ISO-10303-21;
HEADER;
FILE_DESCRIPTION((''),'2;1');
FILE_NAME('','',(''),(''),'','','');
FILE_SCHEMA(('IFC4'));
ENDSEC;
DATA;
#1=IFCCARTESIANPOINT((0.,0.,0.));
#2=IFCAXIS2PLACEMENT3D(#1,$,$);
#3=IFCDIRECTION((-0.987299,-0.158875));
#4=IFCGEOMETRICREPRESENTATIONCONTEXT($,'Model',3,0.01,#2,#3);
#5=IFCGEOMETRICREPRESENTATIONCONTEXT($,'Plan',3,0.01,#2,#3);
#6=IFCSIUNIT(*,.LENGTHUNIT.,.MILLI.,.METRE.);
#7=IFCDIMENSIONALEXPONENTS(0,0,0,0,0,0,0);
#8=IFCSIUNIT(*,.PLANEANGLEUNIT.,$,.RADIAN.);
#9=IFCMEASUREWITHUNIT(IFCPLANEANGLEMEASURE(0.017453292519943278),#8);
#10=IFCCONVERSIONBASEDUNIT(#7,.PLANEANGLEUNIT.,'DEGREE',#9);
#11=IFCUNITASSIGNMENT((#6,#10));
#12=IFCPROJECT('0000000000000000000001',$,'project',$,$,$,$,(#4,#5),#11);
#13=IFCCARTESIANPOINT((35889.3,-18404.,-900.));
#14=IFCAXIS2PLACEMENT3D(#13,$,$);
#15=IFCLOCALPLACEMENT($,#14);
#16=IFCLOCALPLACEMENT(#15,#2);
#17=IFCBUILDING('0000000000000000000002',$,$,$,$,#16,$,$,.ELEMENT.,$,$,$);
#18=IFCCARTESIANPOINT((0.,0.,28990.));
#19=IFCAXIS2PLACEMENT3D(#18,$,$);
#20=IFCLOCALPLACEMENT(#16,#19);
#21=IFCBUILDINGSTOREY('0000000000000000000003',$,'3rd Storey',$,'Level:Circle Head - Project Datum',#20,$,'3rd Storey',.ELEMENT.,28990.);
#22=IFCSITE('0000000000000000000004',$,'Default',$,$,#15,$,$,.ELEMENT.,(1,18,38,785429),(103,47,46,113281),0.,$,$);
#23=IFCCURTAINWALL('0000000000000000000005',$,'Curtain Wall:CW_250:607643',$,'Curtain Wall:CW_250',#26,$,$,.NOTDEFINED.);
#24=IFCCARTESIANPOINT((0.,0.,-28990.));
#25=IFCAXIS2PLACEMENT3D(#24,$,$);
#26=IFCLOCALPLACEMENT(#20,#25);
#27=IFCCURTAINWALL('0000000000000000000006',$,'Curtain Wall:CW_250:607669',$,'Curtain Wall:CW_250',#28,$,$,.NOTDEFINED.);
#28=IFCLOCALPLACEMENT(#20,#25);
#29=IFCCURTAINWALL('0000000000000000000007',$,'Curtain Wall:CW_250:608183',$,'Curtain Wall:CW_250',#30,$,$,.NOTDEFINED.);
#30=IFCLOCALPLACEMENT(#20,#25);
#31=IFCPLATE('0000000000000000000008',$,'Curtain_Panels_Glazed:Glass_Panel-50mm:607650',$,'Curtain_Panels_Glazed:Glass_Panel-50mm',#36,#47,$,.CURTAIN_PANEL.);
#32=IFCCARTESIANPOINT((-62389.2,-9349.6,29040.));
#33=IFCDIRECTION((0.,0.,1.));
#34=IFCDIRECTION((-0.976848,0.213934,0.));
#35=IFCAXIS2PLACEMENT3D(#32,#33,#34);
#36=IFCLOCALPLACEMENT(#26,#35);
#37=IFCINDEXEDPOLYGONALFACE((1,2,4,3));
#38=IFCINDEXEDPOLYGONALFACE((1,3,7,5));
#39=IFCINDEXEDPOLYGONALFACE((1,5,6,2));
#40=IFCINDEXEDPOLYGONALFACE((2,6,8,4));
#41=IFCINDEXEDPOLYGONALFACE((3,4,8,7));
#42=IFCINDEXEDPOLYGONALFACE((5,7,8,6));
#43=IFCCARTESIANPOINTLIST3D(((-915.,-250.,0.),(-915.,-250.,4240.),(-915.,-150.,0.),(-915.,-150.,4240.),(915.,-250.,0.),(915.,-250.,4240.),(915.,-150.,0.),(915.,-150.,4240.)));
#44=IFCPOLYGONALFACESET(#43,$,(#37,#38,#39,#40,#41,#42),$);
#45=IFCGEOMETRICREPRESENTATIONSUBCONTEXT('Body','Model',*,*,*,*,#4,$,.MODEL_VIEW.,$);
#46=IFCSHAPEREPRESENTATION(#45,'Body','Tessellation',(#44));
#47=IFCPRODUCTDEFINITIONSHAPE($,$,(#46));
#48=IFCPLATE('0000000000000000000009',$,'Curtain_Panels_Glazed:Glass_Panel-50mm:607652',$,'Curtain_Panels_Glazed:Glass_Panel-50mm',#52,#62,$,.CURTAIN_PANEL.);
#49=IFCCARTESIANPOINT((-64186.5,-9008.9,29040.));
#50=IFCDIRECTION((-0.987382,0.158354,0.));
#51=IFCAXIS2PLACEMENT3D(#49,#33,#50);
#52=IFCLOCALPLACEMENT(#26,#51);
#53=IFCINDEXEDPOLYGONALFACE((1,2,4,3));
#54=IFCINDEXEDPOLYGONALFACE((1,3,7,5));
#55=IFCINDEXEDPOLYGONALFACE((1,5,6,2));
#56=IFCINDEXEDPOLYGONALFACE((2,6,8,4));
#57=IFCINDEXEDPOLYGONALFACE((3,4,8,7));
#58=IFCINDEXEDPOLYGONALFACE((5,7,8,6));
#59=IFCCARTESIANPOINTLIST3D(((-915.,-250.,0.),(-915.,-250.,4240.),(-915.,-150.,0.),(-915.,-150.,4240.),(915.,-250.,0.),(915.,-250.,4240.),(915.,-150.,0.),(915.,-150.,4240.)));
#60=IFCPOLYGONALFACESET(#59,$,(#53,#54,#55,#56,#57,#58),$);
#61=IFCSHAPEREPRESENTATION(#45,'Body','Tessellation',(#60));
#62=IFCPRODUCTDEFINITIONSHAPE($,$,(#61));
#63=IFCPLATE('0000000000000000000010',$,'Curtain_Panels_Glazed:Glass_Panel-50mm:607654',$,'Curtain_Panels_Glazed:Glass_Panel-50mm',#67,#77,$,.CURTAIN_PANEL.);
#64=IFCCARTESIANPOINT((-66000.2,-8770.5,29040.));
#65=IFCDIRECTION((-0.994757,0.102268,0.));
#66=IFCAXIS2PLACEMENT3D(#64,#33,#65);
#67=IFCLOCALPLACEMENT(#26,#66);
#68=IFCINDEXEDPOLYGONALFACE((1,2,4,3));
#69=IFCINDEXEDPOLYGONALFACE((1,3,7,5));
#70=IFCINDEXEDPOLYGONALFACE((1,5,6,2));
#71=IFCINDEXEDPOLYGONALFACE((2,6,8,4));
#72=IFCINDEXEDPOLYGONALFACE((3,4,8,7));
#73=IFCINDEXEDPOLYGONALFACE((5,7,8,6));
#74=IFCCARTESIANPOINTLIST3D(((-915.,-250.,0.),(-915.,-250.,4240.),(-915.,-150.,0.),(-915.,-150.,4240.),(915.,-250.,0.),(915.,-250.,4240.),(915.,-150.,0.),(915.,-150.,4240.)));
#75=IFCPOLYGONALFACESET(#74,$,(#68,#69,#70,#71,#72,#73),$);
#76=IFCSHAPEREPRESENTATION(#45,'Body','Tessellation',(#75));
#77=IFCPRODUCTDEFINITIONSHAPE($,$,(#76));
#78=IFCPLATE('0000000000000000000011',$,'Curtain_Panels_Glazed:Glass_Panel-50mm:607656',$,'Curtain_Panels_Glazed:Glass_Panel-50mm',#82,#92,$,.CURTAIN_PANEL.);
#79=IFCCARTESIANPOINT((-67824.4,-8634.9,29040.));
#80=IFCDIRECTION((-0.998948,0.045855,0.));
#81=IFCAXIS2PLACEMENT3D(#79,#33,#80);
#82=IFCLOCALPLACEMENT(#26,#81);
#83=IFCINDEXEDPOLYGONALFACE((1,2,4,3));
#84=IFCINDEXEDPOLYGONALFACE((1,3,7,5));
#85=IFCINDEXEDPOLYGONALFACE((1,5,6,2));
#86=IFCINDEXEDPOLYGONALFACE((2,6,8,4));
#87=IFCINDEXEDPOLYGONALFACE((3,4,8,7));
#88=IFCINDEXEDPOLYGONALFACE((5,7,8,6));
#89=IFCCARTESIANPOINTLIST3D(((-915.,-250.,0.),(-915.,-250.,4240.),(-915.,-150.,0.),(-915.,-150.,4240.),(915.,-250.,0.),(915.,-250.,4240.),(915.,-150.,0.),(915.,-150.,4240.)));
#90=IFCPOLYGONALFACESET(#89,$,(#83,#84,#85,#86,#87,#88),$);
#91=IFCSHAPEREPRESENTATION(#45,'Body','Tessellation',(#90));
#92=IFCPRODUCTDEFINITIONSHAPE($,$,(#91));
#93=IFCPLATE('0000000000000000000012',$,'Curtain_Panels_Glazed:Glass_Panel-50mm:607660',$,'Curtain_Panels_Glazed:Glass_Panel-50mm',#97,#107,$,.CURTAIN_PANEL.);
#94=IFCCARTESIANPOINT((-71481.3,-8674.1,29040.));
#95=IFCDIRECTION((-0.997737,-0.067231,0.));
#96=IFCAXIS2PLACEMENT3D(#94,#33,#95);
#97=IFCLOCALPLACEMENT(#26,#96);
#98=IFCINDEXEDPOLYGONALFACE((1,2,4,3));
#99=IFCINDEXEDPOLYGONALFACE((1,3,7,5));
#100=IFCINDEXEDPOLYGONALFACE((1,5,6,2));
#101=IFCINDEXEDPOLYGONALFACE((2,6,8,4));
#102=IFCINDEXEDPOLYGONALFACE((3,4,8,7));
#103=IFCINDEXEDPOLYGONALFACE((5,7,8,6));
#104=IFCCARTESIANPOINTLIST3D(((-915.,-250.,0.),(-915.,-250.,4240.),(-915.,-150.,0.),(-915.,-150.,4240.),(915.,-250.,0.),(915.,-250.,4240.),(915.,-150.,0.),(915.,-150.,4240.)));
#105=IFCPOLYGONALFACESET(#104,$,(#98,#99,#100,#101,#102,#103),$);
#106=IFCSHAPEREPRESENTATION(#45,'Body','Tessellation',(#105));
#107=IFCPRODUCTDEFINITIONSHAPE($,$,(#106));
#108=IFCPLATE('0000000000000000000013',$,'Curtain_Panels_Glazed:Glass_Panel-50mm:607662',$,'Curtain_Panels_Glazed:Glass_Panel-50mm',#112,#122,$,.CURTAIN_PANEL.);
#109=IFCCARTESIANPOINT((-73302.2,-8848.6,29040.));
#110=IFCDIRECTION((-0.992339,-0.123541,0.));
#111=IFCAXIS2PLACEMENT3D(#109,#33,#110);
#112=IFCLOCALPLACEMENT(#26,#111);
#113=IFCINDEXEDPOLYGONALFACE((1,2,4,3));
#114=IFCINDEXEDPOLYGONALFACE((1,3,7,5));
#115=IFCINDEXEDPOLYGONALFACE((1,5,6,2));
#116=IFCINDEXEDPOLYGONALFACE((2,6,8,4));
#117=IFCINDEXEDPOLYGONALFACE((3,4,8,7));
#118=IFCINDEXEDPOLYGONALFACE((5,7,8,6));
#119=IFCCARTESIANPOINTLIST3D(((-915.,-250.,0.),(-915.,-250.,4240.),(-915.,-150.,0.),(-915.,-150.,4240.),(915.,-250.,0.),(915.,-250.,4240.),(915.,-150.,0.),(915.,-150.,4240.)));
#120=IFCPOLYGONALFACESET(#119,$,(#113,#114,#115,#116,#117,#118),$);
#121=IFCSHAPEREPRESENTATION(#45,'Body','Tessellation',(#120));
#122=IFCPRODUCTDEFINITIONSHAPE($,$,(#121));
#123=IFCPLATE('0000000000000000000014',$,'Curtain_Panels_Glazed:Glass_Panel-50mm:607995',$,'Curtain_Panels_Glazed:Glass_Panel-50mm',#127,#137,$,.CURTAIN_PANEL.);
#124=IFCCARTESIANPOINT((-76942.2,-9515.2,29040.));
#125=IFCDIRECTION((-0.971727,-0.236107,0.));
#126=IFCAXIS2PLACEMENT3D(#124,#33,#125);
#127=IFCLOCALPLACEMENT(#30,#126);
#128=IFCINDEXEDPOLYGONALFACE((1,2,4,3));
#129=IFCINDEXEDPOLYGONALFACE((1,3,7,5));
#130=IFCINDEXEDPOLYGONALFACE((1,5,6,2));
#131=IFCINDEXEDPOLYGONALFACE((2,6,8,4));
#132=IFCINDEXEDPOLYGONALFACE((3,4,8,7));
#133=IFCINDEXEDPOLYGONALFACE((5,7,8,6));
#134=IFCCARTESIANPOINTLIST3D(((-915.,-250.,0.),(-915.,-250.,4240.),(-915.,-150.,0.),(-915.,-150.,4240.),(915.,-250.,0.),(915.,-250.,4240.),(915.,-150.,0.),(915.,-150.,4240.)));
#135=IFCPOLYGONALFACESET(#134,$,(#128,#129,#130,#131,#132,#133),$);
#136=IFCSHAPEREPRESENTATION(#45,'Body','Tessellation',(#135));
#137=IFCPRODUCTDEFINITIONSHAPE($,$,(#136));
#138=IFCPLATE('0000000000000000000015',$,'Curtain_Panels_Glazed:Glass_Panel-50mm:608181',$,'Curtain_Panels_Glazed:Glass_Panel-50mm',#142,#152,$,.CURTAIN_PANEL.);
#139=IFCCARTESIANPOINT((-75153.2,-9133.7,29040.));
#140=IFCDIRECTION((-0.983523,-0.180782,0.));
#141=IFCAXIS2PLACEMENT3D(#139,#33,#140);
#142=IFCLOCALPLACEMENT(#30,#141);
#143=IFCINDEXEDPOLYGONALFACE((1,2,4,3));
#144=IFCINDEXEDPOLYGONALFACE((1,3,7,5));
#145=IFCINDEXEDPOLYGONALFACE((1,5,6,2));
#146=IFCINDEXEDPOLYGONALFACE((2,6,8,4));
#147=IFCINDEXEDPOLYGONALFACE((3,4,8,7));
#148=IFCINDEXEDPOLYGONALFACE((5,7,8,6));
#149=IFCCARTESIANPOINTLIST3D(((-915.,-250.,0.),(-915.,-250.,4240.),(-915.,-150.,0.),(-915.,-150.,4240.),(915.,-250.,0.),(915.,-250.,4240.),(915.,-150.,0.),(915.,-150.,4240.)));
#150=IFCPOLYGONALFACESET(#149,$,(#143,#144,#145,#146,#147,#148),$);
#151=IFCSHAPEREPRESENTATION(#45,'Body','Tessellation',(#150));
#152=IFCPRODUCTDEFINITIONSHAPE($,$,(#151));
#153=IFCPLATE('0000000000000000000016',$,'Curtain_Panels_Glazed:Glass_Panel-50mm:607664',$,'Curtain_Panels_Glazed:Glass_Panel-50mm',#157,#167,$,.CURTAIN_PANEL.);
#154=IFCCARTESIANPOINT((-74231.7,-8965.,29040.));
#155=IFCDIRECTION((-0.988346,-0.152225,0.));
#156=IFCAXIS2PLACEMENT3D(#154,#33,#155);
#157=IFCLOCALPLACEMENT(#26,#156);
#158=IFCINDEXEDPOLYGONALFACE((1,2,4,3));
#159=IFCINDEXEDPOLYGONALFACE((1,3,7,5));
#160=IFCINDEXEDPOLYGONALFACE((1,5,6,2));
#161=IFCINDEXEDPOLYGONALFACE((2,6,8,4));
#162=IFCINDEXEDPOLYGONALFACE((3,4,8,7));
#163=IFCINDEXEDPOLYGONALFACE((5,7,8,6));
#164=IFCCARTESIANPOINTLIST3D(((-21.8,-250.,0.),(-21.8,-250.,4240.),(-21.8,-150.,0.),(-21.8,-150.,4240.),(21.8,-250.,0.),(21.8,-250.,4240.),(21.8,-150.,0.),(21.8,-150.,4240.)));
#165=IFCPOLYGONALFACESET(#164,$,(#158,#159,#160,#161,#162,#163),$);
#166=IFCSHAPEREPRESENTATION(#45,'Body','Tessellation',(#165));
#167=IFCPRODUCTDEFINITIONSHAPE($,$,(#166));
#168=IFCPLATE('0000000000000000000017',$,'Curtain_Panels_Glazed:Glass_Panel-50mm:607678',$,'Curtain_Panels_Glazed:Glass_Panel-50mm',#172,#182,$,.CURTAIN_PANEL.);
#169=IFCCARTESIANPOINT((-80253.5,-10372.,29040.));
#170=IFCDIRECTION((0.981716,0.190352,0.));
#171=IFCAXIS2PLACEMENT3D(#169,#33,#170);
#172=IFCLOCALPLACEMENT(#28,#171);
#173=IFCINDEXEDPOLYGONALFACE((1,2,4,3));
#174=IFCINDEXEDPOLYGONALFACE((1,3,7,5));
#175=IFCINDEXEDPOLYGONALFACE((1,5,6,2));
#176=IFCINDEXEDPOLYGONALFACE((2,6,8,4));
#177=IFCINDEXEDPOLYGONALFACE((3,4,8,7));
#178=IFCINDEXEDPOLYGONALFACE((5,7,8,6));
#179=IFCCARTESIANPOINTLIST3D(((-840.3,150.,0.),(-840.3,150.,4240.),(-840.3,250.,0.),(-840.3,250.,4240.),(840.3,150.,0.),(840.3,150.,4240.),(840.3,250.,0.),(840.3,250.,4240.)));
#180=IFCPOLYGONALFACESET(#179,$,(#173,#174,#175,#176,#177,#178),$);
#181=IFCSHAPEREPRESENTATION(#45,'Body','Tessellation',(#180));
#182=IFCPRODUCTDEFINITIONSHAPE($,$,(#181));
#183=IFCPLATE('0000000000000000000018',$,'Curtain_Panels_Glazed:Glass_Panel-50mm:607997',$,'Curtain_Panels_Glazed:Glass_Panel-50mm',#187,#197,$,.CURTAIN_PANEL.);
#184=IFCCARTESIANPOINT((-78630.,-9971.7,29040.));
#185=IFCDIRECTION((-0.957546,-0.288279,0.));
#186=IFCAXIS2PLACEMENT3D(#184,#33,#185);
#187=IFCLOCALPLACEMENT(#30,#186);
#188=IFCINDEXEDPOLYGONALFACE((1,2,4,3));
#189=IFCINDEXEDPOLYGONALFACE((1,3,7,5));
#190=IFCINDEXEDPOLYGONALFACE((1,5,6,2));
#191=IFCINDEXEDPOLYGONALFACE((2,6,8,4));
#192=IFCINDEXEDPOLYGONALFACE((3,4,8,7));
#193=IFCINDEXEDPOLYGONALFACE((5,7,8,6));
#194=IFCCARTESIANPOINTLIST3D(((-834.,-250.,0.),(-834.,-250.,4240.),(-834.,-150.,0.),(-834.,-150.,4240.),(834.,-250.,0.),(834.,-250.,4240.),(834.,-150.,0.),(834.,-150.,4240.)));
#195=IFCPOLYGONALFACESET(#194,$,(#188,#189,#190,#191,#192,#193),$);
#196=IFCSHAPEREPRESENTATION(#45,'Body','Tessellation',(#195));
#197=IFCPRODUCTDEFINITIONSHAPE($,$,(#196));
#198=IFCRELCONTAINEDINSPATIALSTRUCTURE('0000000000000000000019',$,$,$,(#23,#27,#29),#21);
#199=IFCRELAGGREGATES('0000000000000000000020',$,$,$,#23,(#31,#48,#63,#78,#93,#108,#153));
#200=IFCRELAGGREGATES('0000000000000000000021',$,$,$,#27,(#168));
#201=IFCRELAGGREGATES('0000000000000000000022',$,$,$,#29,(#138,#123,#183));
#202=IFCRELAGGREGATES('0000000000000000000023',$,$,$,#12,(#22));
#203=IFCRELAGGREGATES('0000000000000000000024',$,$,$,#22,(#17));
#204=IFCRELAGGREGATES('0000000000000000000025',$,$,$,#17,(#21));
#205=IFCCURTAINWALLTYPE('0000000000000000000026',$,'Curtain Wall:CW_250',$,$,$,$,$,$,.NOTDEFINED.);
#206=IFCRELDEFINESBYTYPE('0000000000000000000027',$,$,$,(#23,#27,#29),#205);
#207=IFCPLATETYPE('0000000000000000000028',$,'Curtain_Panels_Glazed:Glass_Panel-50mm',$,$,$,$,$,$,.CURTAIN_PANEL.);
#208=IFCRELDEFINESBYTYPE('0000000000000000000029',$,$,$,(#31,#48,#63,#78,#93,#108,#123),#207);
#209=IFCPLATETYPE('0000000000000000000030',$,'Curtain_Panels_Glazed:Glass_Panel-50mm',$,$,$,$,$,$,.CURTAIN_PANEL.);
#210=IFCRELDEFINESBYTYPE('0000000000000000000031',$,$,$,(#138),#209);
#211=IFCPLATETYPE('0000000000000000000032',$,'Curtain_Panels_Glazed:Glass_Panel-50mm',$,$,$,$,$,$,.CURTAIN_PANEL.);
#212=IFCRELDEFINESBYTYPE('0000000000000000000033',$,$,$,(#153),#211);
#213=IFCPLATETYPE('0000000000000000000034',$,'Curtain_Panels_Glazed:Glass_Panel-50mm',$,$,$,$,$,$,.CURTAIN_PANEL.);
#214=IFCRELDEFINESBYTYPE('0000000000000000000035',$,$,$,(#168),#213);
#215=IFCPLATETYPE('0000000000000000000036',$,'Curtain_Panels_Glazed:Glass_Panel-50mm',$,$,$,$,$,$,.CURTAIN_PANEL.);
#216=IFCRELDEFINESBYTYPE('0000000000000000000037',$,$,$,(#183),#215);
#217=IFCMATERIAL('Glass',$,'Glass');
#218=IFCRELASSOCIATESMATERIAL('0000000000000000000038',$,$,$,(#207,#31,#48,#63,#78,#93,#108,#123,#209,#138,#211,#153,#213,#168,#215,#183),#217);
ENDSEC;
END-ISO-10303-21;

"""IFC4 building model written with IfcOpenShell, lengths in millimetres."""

from ifc_helpers import new_model, entity, si_unit, converted_unit, direction, frame, origin, place, context, subcontext, project, spatial, indexed_curve, outline, extrude, source, transform, mapped, material, type_object, type_shapes, element, aggregate, save


model = new_model("IFC4")

# Units and contexts
model_context = context("Model", 3, precision=0.01, world=origin(), true_north=direction((-0.987299, -0.158875)))
plan_context = context("Plan", 3, precision=0.01, world=origin(), true_north=direction((-0.987299, -0.158875)))
body_context = subcontext(model_context, "Body", "Model", "MODEL_VIEW")
ifc_project = project(units=[si_unit("LENGTHUNIT", "METRE", prefix="MILLI"), converted_unit("PLANEANGLEUNIT", "DEGREE", entity("IfcPlaneAngleMeasure", 0.017453292519943278), si_unit("PLANEANGLEUNIT", "RADIAN"), dimensions=[0, 0, 0, 0, 0, 0, 0])], contexts=[model_context, plan_context])

# Site, building, storey
site_placement = place(None, frame((35889.3, -18404.0, -900.0)))
site = spatial("IfcSite", under=ifc_project, at=site_placement, Name="Default", CompositionType="ELEMENT", RefLatitude=(1, 18, 38, 785429), RefLongitude=(103, 47, 46, 113281), RefElevation=0.0)
building_placement = place(site_placement, origin())
building = spatial("IfcBuilding", under=site, at=building_placement, CompositionType="ELEMENT")
storey_placement = place(building_placement, frame((0.0, 0.0, 28990.0)))
storey = spatial("IfcBuildingStorey", under=building, at=storey_placement, Name="3rd Storey", ObjectType="Level:Circle Head - Project Datum", LongName="3rd Storey", CompositionType="ELEMENT", Elevation=28990.0)

# Curtain walls
curtain_wall_type = type_object("IfcCurtainWallType", Name="Curtain Wall:CW_250", PredefinedType="NOTDEFINED")
curtain_wall_1_placement = place(storey_placement, frame((0.0, 0.0, -28990.0)))
curtain_wall_1 = element("IfcCurtainWall", 1, at=curtain_wall_1_placement, inside=storey, type_object=curtain_wall_type, Name="Curtain Wall:CW_250:607643", ObjectType="Curtain Wall:CW_250", PredefinedType="NOTDEFINED")
curtain_wall_2_placement = place(storey_placement, frame((0.0, 0.0, -28990.0)))
curtain_wall_2 = element("IfcCurtainWall", 2, at=curtain_wall_2_placement, inside=storey, type_object=curtain_wall_type, Name="Curtain Wall:CW_250:607669", ObjectType="Curtain Wall:CW_250", PredefinedType="NOTDEFINED")
curtain_wall_3_placement = place(storey_placement, frame((0.0, 0.0, -28990.0)))
curtain_wall_3 = element("IfcCurtainWall", 3, at=curtain_wall_3_placement, inside=storey, type_object=curtain_wall_type, Name="Curtain Wall:CW_250:608183", ObjectType="Curtain Wall:CW_250", PredefinedType="NOTDEFINED")

# Plates
ifc_material_1 = material(Name="Glass", Category="Glass")
plate_type_1 = type_object("IfcPlateType", Name="Curtain_Panels_Glazed:Glass_Panel-50mm", PredefinedType="CURTAIN_PANEL", material=ifc_material_1)
shared_shape_1 = source(origin(), body_context, "Body", "SweptSolid", [
    extrude(outline(indexed_curve([(-915.0, -50.0), (915.0, -50.0), (915.0, 50.0), (-915.0, 50.0), (-915.0, -50.0)], self_intersect=False)), frame((0.0, -200.0, 0.0), z_axis=(0.0, 0.0, 1.0), x_axis=(-1.0, 0.0, 0.0)), (0.0, 0.0, 1.0), 4240.0),
])
type_shapes(plate_type_1, [shared_shape_1])
plate_1_placement = place(curtain_wall_1_placement, frame((-62389.2, -9349.6, 29040.0), z_axis=(0.0, 0.0, 1.0), x_axis=(-0.976848, 0.213934, 0.0)))
plate_1 = element("IfcPlate", 4, at=plate_1_placement, type_object=plate_type_1, material=ifc_material_1, Name="Curtain_Panels_Glazed:Glass_Panel-50mm:607650", ObjectType="Curtain_Panels_Glazed:Glass_Panel-50mm", PredefinedType="CURTAIN_PANEL", context=body_context, shape_type="MappedRepresentation", body=[
    mapped(shared_shape_1, transform((0.0, 0.0, 0.0), scale=1.0)),
])
plate_2_placement = place(curtain_wall_1_placement, frame((-64186.5, -9008.9, 29040.0), z_axis=(0.0, 0.0, 1.0), x_axis=(-0.987382, 0.158354, 0.0)))
plate_2 = element("IfcPlate", 5, at=plate_2_placement, type_object=plate_type_1, material=ifc_material_1, Name="Curtain_Panels_Glazed:Glass_Panel-50mm:607652", ObjectType="Curtain_Panels_Glazed:Glass_Panel-50mm", PredefinedType="CURTAIN_PANEL", context=body_context, shape_type="MappedRepresentation", body=[
    mapped(shared_shape_1, transform((0.0, 0.0, 0.0), scale=1.0)),
])
plate_3_placement = place(curtain_wall_1_placement, frame((-66000.2, -8770.5, 29040.0), z_axis=(0.0, 0.0, 1.0), x_axis=(-0.994757, 0.102268, 0.0)))
plate_3 = element("IfcPlate", 6, at=plate_3_placement, type_object=plate_type_1, material=ifc_material_1, Name="Curtain_Panels_Glazed:Glass_Panel-50mm:607654", ObjectType="Curtain_Panels_Glazed:Glass_Panel-50mm", PredefinedType="CURTAIN_PANEL", context=body_context, shape_type="MappedRepresentation", body=[
    mapped(shared_shape_1, transform((0.0, 0.0, 0.0), scale=1.0)),
])
plate_4_placement = place(curtain_wall_1_placement, frame((-67824.4, -8634.9, 29040.0), z_axis=(0.0, 0.0, 1.0), x_axis=(-0.998948, 0.045855, 0.0)))
plate_4 = element("IfcPlate", 7, at=plate_4_placement, type_object=plate_type_1, material=ifc_material_1, Name="Curtain_Panels_Glazed:Glass_Panel-50mm:607656", ObjectType="Curtain_Panels_Glazed:Glass_Panel-50mm", PredefinedType="CURTAIN_PANEL", context=body_context, shape_type="MappedRepresentation", body=[
    mapped(shared_shape_1, transform((0.0, 0.0, 0.0), scale=1.0)),
])
plate_5_placement = place(curtain_wall_1_placement, frame((-71481.3, -8674.1, 29040.0), z_axis=(0.0, 0.0, 1.0), x_axis=(-0.997737, -0.067231, 0.0)))
plate_5 = element("IfcPlate", 8, at=plate_5_placement, type_object=plate_type_1, material=ifc_material_1, Name="Curtain_Panels_Glazed:Glass_Panel-50mm:607660", ObjectType="Curtain_Panels_Glazed:Glass_Panel-50mm", PredefinedType="CURTAIN_PANEL", context=body_context, shape_type="MappedRepresentation", body=[
    mapped(shared_shape_1, transform((0.0, 0.0, 0.0), scale=1.0)),
])
plate_6_placement = place(curtain_wall_1_placement, frame((-73302.2, -8848.6, 29040.0), z_axis=(0.0, 0.0, 1.0), x_axis=(-0.992339, -0.123541, 0.0)))
plate_6 = element("IfcPlate", 9, at=plate_6_placement, type_object=plate_type_1, material=ifc_material_1, Name="Curtain_Panels_Glazed:Glass_Panel-50mm:607662", ObjectType="Curtain_Panels_Glazed:Glass_Panel-50mm", PredefinedType="CURTAIN_PANEL", context=body_context, shape_type="MappedRepresentation", body=[
    mapped(shared_shape_1, transform((0.0, 0.0, 0.0), scale=1.0)),
])
plate_7_placement = place(curtain_wall_3_placement, frame((-76942.2, -9515.2, 29040.0), z_axis=(0.0, 0.0, 1.0), x_axis=(-0.971727, -0.236107, 0.0)))
plate_7 = element("IfcPlate", 10, at=plate_7_placement, type_object=plate_type_1, material=ifc_material_1, Name="Curtain_Panels_Glazed:Glass_Panel-50mm:607995", ObjectType="Curtain_Panels_Glazed:Glass_Panel-50mm", PredefinedType="CURTAIN_PANEL", context=body_context, shape_type="MappedRepresentation", body=[
    mapped(shared_shape_1, transform((0.0, 0.0, 0.0), scale=1.0)),
])
plate_type_2 = type_object("IfcPlateType", Name="Curtain_Panels_Glazed:Glass_Panel-50mm", PredefinedType="CURTAIN_PANEL", material=ifc_material_1)
shared_shape_2 = source(origin(), body_context, "Body", "SweptSolid", [
    extrude(outline(indexed_curve([(-915.0, -50.0), (915.0, -50.0), (915.0, 50.0), (-915.0, 50.0), (-915.0, -50.0)], self_intersect=False)), frame((0.0, -200.0, 0.0), z_axis=(0.0, 0.0, 1.0), x_axis=(-1.0, 0.0, 0.0)), (0.0, 0.0, 1.0), 4240.0),
])
type_shapes(plate_type_2, [shared_shape_2])
plate_8_placement = place(curtain_wall_3_placement, frame((-75153.2, -9133.7, 29040.0), z_axis=(0.0, 0.0, 1.0), x_axis=(-0.983523, -0.180782, 0.0)))
plate_8 = element("IfcPlate", 11, at=plate_8_placement, type_object=plate_type_2, material=ifc_material_1, Name="Curtain_Panels_Glazed:Glass_Panel-50mm:608181", ObjectType="Curtain_Panels_Glazed:Glass_Panel-50mm", PredefinedType="CURTAIN_PANEL", context=body_context, shape_type="MappedRepresentation", body=[
    mapped(shared_shape_2, transform((0.0, 0.0, 0.0), scale=1.0)),
])
plate_type_3 = type_object("IfcPlateType", Name="Curtain_Panels_Glazed:Glass_Panel-50mm", PredefinedType="CURTAIN_PANEL", material=ifc_material_1)
shared_shape_3 = source(origin(), body_context, "Body", "SweptSolid", [
    extrude(outline(indexed_curve([(-21.8, -50.0), (21.8, -50.0), (21.8, 50.0), (-21.8, 50.0), (-21.8, -50.0)], self_intersect=False)), frame((0.0, -200.0, 0.0), z_axis=(0.0, 0.0, 1.0), x_axis=(-1.0, 0.0, 0.0)), (0.0, 0.0, 1.0), 4240.0),
])
type_shapes(plate_type_3, [shared_shape_3])
plate_9_placement = place(curtain_wall_1_placement, frame((-74231.7, -8965.0, 29040.0), z_axis=(0.0, 0.0, 1.0), x_axis=(-0.988346, -0.152225, 0.0)))
plate_9 = element("IfcPlate", 12, at=plate_9_placement, type_object=plate_type_3, material=ifc_material_1, Name="Curtain_Panels_Glazed:Glass_Panel-50mm:607664", ObjectType="Curtain_Panels_Glazed:Glass_Panel-50mm", PredefinedType="CURTAIN_PANEL", context=body_context, shape_type="MappedRepresentation", body=[
    mapped(shared_shape_3, transform((0.0, 0.0, 0.0), scale=1.0)),
])
aggregate(curtain_wall_1, [plate_1, plate_2, plate_3, plate_4, plate_5, plate_6, plate_9])
plate_type_4 = type_object("IfcPlateType", Name="Curtain_Panels_Glazed:Glass_Panel-50mm", PredefinedType="CURTAIN_PANEL", material=ifc_material_1)
shared_shape_4 = source(origin(), body_context, "Body", "SweptSolid", [
    extrude(outline(indexed_curve([(-50.0, -840.3), (50.0, -840.3), (50.0, 840.3), (-50.0, 840.3), (-50.0, -840.3)], self_intersect=False)), frame((0.0, 200.0, 0.0), z_axis=(0.0, 0.0, 1.0), x_axis=(0.0, 1.0, 0.0)), (0.0, 0.0, 1.0), 4240.0),
])
type_shapes(plate_type_4, [shared_shape_4])
plate_10_placement = place(curtain_wall_2_placement, frame((-80253.5, -10372.0, 29040.0), z_axis=(0.0, 0.0, 1.0), x_axis=(0.981716, 0.190352, 0.0)))
plate_10 = element("IfcPlate", 13, at=plate_10_placement, type_object=plate_type_4, material=ifc_material_1, Name="Curtain_Panels_Glazed:Glass_Panel-50mm:607678", ObjectType="Curtain_Panels_Glazed:Glass_Panel-50mm", PredefinedType="CURTAIN_PANEL", context=body_context, shape_type="MappedRepresentation", body=[
    mapped(shared_shape_4, transform((0.0, 0.0, 0.0), scale=1.0)),
])
aggregate(curtain_wall_2, [plate_10])
plate_type_5 = type_object("IfcPlateType", Name="Curtain_Panels_Glazed:Glass_Panel-50mm", PredefinedType="CURTAIN_PANEL", material=ifc_material_1)
shared_shape_5 = source(origin(), body_context, "Body", "SweptSolid", [
    extrude(outline(indexed_curve([(-834.0, -50.0), (834.0, -50.0), (834.0, 50.0), (-834.0, 50.0), (-834.0, -50.0)], self_intersect=False)), frame((0.0, -200.0, 0.0), z_axis=(0.0, 0.0, 1.0), x_axis=(-1.0, 0.0, 0.0)), (0.0, 0.0, 1.0), 4240.0),
])
type_shapes(plate_type_5, [shared_shape_5])
plate_11_placement = place(curtain_wall_3_placement, frame((-78630.0, -9971.7, 29040.0), z_axis=(0.0, 0.0, 1.0), x_axis=(-0.957546, -0.288279, 0.0)))
plate_11 = element("IfcPlate", 14, at=plate_11_placement, type_object=plate_type_5, material=ifc_material_1, Name="Curtain_Panels_Glazed:Glass_Panel-50mm:607997", ObjectType="Curtain_Panels_Glazed:Glass_Panel-50mm", PredefinedType="CURTAIN_PANEL", context=body_context, shape_type="MappedRepresentation", body=[
    mapped(shared_shape_5, transform((0.0, 0.0, 0.0), scale=1.0)),
])
aggregate(curtain_wall_3, [plate_8, plate_7, plate_11])

save(model, "model.ifc")
